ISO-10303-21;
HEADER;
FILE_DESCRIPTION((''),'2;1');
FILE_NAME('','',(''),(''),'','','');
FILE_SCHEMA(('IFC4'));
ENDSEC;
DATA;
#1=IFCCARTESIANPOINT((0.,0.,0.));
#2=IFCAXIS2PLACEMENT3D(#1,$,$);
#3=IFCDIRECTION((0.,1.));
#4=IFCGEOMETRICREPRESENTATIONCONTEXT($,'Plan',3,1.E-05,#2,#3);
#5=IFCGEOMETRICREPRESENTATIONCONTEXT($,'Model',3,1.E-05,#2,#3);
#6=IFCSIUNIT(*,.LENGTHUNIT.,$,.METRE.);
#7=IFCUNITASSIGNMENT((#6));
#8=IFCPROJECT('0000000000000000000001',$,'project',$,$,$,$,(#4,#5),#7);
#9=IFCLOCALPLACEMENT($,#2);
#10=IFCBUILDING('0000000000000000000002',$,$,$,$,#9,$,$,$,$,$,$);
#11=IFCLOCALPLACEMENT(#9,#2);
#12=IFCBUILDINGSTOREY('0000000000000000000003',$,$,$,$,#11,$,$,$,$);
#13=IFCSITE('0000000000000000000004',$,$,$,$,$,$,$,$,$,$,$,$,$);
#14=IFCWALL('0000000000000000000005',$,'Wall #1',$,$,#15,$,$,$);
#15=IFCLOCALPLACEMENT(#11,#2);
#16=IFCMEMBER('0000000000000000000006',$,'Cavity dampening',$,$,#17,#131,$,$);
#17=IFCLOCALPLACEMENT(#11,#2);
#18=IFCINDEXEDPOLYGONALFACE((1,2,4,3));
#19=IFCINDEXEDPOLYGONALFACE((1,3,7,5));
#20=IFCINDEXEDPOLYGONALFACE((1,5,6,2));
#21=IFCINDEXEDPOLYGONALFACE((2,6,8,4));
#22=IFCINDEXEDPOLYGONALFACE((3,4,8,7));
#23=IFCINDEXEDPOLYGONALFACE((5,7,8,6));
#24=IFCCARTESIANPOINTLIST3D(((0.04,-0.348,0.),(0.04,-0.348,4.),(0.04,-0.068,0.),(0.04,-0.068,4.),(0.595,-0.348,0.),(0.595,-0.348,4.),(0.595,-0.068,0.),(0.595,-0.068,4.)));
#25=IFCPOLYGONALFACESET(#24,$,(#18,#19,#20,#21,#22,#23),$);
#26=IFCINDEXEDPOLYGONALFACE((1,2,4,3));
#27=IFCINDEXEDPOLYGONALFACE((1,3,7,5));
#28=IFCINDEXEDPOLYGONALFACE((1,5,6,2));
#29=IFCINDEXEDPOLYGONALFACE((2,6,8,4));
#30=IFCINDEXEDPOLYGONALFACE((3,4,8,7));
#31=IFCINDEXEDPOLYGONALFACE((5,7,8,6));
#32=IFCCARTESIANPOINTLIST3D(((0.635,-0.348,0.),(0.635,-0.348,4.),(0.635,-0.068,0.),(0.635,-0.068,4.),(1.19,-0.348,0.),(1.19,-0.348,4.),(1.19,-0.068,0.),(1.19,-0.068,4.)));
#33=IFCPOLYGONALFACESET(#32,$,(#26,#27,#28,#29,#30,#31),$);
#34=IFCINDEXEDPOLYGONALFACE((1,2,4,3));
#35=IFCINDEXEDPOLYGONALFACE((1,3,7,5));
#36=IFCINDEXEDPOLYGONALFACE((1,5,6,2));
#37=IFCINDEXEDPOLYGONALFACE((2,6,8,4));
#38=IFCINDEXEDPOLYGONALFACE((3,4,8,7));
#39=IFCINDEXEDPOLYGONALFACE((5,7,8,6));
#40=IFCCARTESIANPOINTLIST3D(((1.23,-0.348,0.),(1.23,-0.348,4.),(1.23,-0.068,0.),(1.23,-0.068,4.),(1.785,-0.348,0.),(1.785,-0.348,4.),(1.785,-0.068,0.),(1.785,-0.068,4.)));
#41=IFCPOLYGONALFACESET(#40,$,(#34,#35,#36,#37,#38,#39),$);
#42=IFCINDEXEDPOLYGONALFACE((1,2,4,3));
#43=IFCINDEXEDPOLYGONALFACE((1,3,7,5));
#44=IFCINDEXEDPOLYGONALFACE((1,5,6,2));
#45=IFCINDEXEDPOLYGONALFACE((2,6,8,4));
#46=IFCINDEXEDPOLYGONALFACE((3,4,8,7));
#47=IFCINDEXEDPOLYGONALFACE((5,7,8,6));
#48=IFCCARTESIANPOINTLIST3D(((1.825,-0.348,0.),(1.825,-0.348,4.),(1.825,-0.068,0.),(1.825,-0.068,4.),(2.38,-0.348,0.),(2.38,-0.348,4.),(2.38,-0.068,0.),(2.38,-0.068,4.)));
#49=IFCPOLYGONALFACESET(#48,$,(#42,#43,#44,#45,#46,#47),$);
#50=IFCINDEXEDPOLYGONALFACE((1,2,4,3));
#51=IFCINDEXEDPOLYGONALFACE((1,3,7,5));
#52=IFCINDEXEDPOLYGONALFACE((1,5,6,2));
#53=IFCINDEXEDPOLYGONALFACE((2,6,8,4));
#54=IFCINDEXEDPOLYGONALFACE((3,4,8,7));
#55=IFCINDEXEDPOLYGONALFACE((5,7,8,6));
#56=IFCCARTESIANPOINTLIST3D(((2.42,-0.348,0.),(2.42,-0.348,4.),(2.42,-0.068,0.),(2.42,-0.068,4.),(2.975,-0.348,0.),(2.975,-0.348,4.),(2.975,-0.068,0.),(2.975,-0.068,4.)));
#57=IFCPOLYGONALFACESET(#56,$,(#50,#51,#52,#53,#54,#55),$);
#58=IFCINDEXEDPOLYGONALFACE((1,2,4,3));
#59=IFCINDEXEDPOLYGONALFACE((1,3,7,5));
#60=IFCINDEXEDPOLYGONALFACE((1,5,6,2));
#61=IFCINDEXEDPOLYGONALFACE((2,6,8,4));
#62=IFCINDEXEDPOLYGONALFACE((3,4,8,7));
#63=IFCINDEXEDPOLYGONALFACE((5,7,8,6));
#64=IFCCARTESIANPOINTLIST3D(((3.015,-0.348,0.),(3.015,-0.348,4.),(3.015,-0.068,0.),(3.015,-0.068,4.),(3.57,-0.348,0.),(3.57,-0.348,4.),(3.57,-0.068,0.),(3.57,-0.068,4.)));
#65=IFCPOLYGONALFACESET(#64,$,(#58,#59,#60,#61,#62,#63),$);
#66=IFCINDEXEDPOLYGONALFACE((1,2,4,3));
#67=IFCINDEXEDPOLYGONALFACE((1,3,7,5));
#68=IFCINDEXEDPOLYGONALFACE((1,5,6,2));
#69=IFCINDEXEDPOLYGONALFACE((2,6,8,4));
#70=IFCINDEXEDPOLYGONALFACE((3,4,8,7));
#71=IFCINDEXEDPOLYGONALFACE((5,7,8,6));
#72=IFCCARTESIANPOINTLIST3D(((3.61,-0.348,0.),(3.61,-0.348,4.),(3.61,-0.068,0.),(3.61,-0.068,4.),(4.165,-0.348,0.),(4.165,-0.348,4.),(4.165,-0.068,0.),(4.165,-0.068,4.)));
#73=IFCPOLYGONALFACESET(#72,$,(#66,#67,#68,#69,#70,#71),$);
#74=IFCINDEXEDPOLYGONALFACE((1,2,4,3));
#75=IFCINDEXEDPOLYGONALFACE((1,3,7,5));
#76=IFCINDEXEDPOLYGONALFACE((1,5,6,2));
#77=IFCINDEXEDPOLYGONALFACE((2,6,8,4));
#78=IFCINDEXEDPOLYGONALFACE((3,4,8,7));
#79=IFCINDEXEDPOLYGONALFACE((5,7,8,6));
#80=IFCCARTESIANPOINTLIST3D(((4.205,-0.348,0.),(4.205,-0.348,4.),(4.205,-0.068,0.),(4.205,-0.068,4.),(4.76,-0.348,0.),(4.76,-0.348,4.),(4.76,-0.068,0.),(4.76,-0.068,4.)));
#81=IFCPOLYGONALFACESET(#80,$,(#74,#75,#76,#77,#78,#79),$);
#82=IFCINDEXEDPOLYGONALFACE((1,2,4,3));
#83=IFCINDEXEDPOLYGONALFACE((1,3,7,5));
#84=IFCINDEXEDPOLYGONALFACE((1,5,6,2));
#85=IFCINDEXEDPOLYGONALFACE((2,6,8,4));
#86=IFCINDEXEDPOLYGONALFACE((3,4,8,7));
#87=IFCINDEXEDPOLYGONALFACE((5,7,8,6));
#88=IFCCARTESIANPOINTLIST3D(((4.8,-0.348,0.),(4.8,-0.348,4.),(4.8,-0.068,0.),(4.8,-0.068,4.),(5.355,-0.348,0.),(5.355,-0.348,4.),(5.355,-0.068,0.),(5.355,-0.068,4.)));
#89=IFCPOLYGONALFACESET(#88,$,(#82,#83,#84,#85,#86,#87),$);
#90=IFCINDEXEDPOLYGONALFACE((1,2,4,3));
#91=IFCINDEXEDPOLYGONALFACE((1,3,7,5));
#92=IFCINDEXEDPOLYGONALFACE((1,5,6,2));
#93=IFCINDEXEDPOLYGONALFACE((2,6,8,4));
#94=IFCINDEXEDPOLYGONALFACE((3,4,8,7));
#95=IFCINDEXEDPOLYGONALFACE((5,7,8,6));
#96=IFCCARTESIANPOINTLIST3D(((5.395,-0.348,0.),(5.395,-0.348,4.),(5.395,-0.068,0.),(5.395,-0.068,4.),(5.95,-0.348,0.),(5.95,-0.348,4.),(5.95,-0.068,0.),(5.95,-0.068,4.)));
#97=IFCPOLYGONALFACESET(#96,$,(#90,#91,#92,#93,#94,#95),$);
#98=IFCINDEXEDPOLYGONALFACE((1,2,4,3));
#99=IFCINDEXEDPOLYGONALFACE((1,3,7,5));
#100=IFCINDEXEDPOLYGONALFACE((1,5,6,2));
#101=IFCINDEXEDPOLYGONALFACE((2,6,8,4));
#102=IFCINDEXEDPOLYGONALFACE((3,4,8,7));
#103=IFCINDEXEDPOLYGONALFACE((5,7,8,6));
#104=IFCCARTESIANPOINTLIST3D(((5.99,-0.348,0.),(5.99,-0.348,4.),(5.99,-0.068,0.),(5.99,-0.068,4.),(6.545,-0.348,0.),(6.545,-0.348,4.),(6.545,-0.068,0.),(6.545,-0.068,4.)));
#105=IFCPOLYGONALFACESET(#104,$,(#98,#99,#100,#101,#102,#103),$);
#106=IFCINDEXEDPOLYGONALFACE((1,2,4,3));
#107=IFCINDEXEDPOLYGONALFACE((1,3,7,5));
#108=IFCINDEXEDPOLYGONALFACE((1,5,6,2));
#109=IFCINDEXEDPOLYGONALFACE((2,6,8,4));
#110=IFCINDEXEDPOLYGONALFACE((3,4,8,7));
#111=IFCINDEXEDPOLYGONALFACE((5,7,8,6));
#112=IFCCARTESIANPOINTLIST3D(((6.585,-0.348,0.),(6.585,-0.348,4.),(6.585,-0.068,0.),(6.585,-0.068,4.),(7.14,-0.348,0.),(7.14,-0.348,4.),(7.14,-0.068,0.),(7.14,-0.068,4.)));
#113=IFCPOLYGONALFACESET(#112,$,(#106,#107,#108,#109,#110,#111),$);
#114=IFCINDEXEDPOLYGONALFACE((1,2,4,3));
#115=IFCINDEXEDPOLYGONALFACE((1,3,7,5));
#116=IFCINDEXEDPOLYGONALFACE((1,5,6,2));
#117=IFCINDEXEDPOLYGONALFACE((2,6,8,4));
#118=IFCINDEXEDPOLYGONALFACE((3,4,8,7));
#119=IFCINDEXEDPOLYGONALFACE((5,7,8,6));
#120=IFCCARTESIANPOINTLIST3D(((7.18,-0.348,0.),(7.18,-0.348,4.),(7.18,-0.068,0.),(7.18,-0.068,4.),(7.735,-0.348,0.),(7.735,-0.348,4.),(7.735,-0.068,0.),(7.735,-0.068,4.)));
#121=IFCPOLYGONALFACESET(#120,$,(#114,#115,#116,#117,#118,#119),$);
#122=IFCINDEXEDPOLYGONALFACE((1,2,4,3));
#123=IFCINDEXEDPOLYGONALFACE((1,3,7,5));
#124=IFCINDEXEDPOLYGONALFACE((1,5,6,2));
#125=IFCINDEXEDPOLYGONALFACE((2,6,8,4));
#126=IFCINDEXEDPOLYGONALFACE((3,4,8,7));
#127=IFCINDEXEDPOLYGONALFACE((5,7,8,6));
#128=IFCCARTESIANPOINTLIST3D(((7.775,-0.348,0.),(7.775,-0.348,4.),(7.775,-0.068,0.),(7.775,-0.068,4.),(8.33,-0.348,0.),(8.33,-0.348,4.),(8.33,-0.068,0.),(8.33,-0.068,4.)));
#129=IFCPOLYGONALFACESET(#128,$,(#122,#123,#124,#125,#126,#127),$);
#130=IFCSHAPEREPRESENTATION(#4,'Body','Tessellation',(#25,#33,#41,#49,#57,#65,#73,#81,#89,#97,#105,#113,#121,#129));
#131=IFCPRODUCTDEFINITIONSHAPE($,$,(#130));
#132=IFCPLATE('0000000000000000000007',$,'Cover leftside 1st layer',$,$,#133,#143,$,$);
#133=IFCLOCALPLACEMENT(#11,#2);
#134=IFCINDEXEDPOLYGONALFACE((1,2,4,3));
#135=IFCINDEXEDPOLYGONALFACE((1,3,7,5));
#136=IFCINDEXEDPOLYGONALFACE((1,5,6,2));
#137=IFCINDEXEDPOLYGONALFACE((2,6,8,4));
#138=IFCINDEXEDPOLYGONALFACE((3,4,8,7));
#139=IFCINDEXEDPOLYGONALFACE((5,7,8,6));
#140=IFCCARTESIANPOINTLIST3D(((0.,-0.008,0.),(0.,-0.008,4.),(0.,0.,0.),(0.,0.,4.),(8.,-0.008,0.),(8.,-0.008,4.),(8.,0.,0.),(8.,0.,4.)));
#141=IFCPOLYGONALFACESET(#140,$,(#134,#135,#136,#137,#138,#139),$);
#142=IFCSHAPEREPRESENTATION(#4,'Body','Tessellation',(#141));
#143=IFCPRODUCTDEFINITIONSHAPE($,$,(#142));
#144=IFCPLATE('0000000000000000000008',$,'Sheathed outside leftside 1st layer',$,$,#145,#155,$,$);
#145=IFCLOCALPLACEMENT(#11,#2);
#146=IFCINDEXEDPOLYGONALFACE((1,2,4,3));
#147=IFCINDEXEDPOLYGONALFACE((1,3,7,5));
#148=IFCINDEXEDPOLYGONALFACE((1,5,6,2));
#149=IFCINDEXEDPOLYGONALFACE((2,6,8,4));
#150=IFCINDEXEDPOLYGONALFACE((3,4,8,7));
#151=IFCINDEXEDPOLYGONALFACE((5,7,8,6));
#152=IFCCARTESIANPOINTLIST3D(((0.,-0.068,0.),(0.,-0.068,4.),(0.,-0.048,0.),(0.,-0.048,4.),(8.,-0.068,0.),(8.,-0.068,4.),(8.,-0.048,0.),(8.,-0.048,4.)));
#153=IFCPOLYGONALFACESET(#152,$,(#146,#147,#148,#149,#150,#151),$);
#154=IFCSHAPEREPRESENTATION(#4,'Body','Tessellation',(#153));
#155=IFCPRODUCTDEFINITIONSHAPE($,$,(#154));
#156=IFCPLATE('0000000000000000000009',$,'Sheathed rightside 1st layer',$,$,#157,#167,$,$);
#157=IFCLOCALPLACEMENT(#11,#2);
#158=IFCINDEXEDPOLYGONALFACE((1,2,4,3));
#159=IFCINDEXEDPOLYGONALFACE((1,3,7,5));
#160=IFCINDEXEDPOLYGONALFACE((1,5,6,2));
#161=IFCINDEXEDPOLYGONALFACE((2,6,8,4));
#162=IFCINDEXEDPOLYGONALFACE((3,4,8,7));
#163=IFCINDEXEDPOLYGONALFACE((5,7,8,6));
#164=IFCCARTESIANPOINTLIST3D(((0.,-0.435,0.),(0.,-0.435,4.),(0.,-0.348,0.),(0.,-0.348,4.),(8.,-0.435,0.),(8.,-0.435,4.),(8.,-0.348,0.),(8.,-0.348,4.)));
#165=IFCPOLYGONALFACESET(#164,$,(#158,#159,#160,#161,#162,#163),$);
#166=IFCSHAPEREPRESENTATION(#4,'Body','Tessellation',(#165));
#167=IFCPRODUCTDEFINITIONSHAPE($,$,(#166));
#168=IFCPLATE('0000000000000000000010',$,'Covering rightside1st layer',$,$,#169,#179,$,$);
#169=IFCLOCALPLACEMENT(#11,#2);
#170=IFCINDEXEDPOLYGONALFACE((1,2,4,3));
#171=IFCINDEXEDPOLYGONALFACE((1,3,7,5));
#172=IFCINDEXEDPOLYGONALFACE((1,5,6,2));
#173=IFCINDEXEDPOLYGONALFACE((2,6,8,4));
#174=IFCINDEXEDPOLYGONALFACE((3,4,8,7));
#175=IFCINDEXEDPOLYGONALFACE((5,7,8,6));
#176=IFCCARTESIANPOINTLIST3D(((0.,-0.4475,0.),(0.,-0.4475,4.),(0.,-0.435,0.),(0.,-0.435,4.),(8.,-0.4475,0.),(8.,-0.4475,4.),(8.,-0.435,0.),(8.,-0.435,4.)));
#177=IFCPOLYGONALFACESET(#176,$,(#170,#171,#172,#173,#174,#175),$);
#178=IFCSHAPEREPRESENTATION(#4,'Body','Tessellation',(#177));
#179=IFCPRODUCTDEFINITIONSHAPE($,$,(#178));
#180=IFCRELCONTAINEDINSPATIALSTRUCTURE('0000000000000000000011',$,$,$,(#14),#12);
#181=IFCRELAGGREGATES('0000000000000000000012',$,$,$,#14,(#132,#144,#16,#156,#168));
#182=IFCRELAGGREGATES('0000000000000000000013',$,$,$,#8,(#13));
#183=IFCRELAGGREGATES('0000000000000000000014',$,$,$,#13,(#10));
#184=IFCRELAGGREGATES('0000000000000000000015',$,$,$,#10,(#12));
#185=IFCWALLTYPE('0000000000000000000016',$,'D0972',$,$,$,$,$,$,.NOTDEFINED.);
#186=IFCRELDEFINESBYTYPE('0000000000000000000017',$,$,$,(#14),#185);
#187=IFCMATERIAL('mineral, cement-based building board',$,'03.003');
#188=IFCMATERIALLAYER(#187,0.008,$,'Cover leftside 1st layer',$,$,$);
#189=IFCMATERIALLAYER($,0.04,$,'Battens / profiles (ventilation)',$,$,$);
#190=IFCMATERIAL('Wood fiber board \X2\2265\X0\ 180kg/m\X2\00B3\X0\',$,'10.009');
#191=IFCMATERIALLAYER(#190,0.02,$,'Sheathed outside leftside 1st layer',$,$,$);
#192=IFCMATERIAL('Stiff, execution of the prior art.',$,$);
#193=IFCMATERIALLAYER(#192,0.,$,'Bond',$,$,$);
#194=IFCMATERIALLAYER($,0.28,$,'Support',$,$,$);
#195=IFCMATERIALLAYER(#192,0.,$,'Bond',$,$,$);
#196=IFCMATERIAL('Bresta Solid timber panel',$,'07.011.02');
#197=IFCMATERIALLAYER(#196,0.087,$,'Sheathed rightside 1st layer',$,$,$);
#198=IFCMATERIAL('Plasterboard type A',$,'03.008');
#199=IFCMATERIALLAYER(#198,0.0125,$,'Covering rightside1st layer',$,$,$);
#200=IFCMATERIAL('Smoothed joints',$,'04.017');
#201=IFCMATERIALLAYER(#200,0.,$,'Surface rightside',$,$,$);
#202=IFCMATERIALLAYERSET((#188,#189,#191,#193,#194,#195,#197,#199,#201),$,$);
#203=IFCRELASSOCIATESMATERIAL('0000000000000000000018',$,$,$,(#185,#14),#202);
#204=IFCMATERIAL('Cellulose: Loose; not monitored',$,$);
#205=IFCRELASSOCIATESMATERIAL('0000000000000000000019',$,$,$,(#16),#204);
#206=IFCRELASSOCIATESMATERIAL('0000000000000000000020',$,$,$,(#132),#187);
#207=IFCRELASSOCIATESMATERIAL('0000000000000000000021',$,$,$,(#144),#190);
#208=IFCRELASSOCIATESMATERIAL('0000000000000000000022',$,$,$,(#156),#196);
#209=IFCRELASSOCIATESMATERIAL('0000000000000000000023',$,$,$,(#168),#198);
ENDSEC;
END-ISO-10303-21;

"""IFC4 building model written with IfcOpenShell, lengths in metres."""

from ifc_helpers import new_model, si_unit, direction, frame, frame_2d, origin, origin_with_axes, place, context, project, spatial, rectangle, extrude, material, layer, layer_set, type_object, element, aggregate, save


model = new_model("IFC4")

# Units and contexts
plan_context = context("Plan", 3, precision=1e-05, world=origin(), true_north=direction((0.0, 1.0)))
model_context = context("Model", 3, precision=1e-05, world=origin(), true_north=direction((0.0, 1.0)))
ifc_project = project(units=[si_unit("LENGTHUNIT", "METRE")], contexts=[plan_context, model_context])

# Site, building, storey
site = spatial("IfcSite", under=ifc_project)
building_placement = place(None, origin())
building = spatial("IfcBuilding", under=site, at=building_placement)
storey_placement = place(building_placement, origin())
storey = spatial("IfcBuildingStorey", under=building, at=storey_placement)

# Wall, member, plates
ifc_material_1 = material(Name="mineral, cement-based building board", Category="03.003")
ifc_layer_1 = layer(ifc_material_1, 0.008, Name="Cover leftside 1st layer")
ifc_layer_2 = layer(None, 0.04, Name="Battens / profiles (ventilation)")
ifc_material_2 = material(Name="Wood fiber board ≥ 180kg/m³", Category="10.009")
ifc_layer_3 = layer(ifc_material_2, 0.02, Name="Sheathed outside leftside 1st layer")
ifc_material_3 = material(Name="Stiff, execution of the prior art.")
ifc_layer_4 = layer(ifc_material_3, 0.0, Name="Bond")
ifc_layer_5 = layer(None, 0.28, Name="Support")
ifc_layer_6 = layer(ifc_material_3, 0.0, Name="Bond")
ifc_material_4 = material(Name="Bresta Solid timber panel", Category="07.011.02")
ifc_layer_7 = layer(ifc_material_4, 0.087, Name="Sheathed rightside 1st layer")
ifc_material_5 = material(Name="Plasterboard type A", Category="03.008")
ifc_layer_8 = layer(ifc_material_5, 0.0125, Name="Covering rightside1st layer")
ifc_material_6 = material(Name="Smoothed joints", Category="04.017")
ifc_layer_9 = layer(ifc_material_6, 0.0, Name="Surface rightside")
ifc_layer_set = layer_set([ifc_layer_1, ifc_layer_2, ifc_layer_3, ifc_layer_4, ifc_layer_5, ifc_layer_6, ifc_layer_7, ifc_layer_8, ifc_layer_9])
wall_type = type_object("IfcWallType", Name="D0972", PredefinedType="NOTDEFINED", material=ifc_layer_set)
wall_placement = place(None, frame((0.0, 0.0, 0.0), z_axis=(0.0, -1.0, 0.0), x_axis=(1.0, 0.0, 0.0)))
wall = element("IfcWall", 1, at=wall_placement, inside=storey, type_object=wall_type, material=ifc_layer_set, Name="Wall #1")
ifc_material_7 = material(Name="Cellulose: Loose; not monitored")
member_1_placement = place(wall_placement, origin())
member_1 = element("IfcMember", 2, at=member_1_placement, material=ifc_material_7, Name="Cavity dampening", context=plan_context, shape_type="SweptSolid", body=[
    extrude(rectangle(XDim=0.555, YDim=0.28, at=frame_2d((0.2775, 0.14), x_axis=(1.0, 0.0))), frame((0.04, 4.0, 0.068), z_axis=(0.0, -1.0, 0.0), x_axis=(1.0, 0.0, 0.0)), (0.0, 0.0, 1.0), 4.0),
    extrude(rectangle(XDim=0.555, YDim=0.28, at=frame_2d((0.2775, 0.14), x_axis=(1.0, 0.0))), frame((0.635, 4.0, 0.068), z_axis=(0.0, -1.0, 0.0), x_axis=(1.0, 0.0, 0.0)), (0.0, 0.0, 1.0), 4.0),
    extrude(rectangle(XDim=0.555, YDim=0.28, at=frame_2d((0.2775, 0.14), x_axis=(1.0, 0.0))), frame((1.23, 4.0, 0.068), z_axis=(0.0, -1.0, 0.0), x_axis=(1.0, 0.0, 0.0)), (0.0, 0.0, 1.0), 4.0),
    extrude(rectangle(XDim=0.555, YDim=0.28, at=frame_2d((0.2775, 0.14), x_axis=(1.0, 0.0))), frame((1.825, 4.0, 0.068), z_axis=(0.0, -1.0, 0.0), x_axis=(1.0, 0.0, 0.0)), (0.0, 0.0, 1.0), 4.0),
    extrude(rectangle(XDim=0.555, YDim=0.28, at=frame_2d((0.2775, 0.14), x_axis=(1.0, 0.0))), frame((2.42, 4.0, 0.068), z_axis=(0.0, -1.0, 0.0), x_axis=(1.0, 0.0, 0.0)), (0.0, 0.0, 1.0), 4.0),
    extrude(rectangle(XDim=0.555, YDim=0.28, at=frame_2d((0.2775, 0.14), x_axis=(1.0, 0.0))), frame((3.015, 4.0, 0.068), z_axis=(0.0, -1.0, 0.0), x_axis=(1.0, 0.0, 0.0)), (0.0, 0.0, 1.0), 4.0),
    extrude(rectangle(XDim=0.555, YDim=0.28, at=frame_2d((0.2775, 0.14), x_axis=(1.0, 0.0))), frame((3.61, 4.0, 0.068), z_axis=(0.0, -1.0, 0.0), x_axis=(1.0, 0.0, 0.0)), (0.0, 0.0, 1.0), 4.0),
    extrude(rectangle(XDim=0.555, YDim=0.28, at=frame_2d((0.2775, 0.14), x_axis=(1.0, 0.0))), frame((4.205, 4.0, 0.068), z_axis=(0.0, -1.0, 0.0), x_axis=(1.0, 0.0, 0.0)), (0.0, 0.0, 1.0), 4.0),
    extrude(rectangle(XDim=0.555, YDim=0.28, at=frame_2d((0.2775, 0.14), x_axis=(1.0, 0.0))), frame((4.8, 4.0, 0.068), z_axis=(0.0, -1.0, 0.0), x_axis=(1.0, 0.0, 0.0)), (0.0, 0.0, 1.0), 4.0),
    extrude(rectangle(XDim=0.555, YDim=0.28, at=frame_2d((0.2775, 0.14), x_axis=(1.0, 0.0))), frame((5.395, 4.0, 0.068), z_axis=(0.0, -1.0, 0.0), x_axis=(1.0, 0.0, 0.0)), (0.0, 0.0, 1.0), 4.0),
    extrude(rectangle(XDim=0.555, YDim=0.28, at=frame_2d((0.2775, 0.14), x_axis=(1.0, 0.0))), frame((5.99, 4.0, 0.068), z_axis=(0.0, -1.0, 0.0), x_axis=(1.0, 0.0, 0.0)), (0.0, 0.0, 1.0), 4.0),
    extrude(rectangle(XDim=0.555, YDim=0.28, at=frame_2d((0.2775, 0.14), x_axis=(1.0, 0.0))), frame((6.585, 4.0, 0.068), z_axis=(0.0, -1.0, 0.0), x_axis=(1.0, 0.0, 0.0)), (0.0, 0.0, 1.0), 4.0),
    extrude(rectangle(XDim=0.555, YDim=0.28, at=frame_2d((0.2775, 0.14), x_axis=(1.0, 0.0))), frame((7.18, 4.0, 0.068), z_axis=(0.0, -1.0, 0.0), x_axis=(1.0, 0.0, 0.0)), (0.0, 0.0, 1.0), 4.0),
    extrude(rectangle(XDim=0.555, YDim=0.28, at=frame_2d((0.2775, 0.14), x_axis=(1.0, 0.0))), frame((7.775, 4.0, 0.068), z_axis=(0.0, -1.0, 0.0), x_axis=(1.0, 0.0, 0.0)), (0.0, 0.0, 1.0), 4.0),
])
plate_1_placement = place(wall_placement, origin())
plate_1 = element("IfcPlate", 3, at=plate_1_placement, material=ifc_material_1, Name="Cover leftside 1st layer", context=plan_context, shape_type="SweptSolid", body=[
    extrude(rectangle(XDim=8.0, YDim=4.0, at=frame_2d((4.0, 2.0), x_axis=(1.0, 0.0))), origin_with_axes(), (0.0, 0.0, 1.0), 0.008),
])
plate_2_placement = place(wall_placement, origin())
plate_2 = element("IfcPlate", 4, at=plate_2_placement, material=ifc_material_2, Name="Sheathed outside leftside 1st layer", context=plan_context, shape_type="SweptSolid", body=[
    extrude(rectangle(XDim=8.0, YDim=4.0, at=frame_2d((4.0, 2.0), x_axis=(1.0, 0.0))), frame((0.0, 0.0, 0.048), z_axis=(0.0, 0.0, 1.0), x_axis=(1.0, 0.0, 0.0)), (0.0, 0.0, 1.0), 0.02),
])
plate_3_placement = place(wall_placement, origin())
plate_3 = element("IfcPlate", 5, at=plate_3_placement, material=ifc_material_4, Name="Sheathed rightside 1st layer", context=plan_context, shape_type="SweptSolid", body=[
    extrude(rectangle(XDim=8.0, YDim=4.0, at=frame_2d((4.0, 2.0), x_axis=(1.0, 0.0))), frame((0.0, 0.0, 0.348), z_axis=(0.0, 0.0, 1.0), x_axis=(1.0, 0.0, 0.0)), (0.0, 0.0, 1.0), 0.087),
])
plate_4_placement = place(wall_placement, origin())
plate_4 = element("IfcPlate", 6, at=plate_4_placement, material=ifc_material_5, Name="Covering rightside1st layer", context=plan_context, shape_type="SweptSolid", body=[
    extrude(rectangle(XDim=8.0, YDim=4.0, at=frame_2d((4.0, 2.0), x_axis=(1.0, 0.0))), frame((0.0, 0.0, 0.435), z_axis=(0.0, 0.0, 1.0), x_axis=(1.0, 0.0, 0.0)), (0.0, 0.0, 1.0), 0.0125),
])
aggregate(wall, [plate_1, plate_2, member_1, plate_3, plate_4])

save(model, "model.ifc")
